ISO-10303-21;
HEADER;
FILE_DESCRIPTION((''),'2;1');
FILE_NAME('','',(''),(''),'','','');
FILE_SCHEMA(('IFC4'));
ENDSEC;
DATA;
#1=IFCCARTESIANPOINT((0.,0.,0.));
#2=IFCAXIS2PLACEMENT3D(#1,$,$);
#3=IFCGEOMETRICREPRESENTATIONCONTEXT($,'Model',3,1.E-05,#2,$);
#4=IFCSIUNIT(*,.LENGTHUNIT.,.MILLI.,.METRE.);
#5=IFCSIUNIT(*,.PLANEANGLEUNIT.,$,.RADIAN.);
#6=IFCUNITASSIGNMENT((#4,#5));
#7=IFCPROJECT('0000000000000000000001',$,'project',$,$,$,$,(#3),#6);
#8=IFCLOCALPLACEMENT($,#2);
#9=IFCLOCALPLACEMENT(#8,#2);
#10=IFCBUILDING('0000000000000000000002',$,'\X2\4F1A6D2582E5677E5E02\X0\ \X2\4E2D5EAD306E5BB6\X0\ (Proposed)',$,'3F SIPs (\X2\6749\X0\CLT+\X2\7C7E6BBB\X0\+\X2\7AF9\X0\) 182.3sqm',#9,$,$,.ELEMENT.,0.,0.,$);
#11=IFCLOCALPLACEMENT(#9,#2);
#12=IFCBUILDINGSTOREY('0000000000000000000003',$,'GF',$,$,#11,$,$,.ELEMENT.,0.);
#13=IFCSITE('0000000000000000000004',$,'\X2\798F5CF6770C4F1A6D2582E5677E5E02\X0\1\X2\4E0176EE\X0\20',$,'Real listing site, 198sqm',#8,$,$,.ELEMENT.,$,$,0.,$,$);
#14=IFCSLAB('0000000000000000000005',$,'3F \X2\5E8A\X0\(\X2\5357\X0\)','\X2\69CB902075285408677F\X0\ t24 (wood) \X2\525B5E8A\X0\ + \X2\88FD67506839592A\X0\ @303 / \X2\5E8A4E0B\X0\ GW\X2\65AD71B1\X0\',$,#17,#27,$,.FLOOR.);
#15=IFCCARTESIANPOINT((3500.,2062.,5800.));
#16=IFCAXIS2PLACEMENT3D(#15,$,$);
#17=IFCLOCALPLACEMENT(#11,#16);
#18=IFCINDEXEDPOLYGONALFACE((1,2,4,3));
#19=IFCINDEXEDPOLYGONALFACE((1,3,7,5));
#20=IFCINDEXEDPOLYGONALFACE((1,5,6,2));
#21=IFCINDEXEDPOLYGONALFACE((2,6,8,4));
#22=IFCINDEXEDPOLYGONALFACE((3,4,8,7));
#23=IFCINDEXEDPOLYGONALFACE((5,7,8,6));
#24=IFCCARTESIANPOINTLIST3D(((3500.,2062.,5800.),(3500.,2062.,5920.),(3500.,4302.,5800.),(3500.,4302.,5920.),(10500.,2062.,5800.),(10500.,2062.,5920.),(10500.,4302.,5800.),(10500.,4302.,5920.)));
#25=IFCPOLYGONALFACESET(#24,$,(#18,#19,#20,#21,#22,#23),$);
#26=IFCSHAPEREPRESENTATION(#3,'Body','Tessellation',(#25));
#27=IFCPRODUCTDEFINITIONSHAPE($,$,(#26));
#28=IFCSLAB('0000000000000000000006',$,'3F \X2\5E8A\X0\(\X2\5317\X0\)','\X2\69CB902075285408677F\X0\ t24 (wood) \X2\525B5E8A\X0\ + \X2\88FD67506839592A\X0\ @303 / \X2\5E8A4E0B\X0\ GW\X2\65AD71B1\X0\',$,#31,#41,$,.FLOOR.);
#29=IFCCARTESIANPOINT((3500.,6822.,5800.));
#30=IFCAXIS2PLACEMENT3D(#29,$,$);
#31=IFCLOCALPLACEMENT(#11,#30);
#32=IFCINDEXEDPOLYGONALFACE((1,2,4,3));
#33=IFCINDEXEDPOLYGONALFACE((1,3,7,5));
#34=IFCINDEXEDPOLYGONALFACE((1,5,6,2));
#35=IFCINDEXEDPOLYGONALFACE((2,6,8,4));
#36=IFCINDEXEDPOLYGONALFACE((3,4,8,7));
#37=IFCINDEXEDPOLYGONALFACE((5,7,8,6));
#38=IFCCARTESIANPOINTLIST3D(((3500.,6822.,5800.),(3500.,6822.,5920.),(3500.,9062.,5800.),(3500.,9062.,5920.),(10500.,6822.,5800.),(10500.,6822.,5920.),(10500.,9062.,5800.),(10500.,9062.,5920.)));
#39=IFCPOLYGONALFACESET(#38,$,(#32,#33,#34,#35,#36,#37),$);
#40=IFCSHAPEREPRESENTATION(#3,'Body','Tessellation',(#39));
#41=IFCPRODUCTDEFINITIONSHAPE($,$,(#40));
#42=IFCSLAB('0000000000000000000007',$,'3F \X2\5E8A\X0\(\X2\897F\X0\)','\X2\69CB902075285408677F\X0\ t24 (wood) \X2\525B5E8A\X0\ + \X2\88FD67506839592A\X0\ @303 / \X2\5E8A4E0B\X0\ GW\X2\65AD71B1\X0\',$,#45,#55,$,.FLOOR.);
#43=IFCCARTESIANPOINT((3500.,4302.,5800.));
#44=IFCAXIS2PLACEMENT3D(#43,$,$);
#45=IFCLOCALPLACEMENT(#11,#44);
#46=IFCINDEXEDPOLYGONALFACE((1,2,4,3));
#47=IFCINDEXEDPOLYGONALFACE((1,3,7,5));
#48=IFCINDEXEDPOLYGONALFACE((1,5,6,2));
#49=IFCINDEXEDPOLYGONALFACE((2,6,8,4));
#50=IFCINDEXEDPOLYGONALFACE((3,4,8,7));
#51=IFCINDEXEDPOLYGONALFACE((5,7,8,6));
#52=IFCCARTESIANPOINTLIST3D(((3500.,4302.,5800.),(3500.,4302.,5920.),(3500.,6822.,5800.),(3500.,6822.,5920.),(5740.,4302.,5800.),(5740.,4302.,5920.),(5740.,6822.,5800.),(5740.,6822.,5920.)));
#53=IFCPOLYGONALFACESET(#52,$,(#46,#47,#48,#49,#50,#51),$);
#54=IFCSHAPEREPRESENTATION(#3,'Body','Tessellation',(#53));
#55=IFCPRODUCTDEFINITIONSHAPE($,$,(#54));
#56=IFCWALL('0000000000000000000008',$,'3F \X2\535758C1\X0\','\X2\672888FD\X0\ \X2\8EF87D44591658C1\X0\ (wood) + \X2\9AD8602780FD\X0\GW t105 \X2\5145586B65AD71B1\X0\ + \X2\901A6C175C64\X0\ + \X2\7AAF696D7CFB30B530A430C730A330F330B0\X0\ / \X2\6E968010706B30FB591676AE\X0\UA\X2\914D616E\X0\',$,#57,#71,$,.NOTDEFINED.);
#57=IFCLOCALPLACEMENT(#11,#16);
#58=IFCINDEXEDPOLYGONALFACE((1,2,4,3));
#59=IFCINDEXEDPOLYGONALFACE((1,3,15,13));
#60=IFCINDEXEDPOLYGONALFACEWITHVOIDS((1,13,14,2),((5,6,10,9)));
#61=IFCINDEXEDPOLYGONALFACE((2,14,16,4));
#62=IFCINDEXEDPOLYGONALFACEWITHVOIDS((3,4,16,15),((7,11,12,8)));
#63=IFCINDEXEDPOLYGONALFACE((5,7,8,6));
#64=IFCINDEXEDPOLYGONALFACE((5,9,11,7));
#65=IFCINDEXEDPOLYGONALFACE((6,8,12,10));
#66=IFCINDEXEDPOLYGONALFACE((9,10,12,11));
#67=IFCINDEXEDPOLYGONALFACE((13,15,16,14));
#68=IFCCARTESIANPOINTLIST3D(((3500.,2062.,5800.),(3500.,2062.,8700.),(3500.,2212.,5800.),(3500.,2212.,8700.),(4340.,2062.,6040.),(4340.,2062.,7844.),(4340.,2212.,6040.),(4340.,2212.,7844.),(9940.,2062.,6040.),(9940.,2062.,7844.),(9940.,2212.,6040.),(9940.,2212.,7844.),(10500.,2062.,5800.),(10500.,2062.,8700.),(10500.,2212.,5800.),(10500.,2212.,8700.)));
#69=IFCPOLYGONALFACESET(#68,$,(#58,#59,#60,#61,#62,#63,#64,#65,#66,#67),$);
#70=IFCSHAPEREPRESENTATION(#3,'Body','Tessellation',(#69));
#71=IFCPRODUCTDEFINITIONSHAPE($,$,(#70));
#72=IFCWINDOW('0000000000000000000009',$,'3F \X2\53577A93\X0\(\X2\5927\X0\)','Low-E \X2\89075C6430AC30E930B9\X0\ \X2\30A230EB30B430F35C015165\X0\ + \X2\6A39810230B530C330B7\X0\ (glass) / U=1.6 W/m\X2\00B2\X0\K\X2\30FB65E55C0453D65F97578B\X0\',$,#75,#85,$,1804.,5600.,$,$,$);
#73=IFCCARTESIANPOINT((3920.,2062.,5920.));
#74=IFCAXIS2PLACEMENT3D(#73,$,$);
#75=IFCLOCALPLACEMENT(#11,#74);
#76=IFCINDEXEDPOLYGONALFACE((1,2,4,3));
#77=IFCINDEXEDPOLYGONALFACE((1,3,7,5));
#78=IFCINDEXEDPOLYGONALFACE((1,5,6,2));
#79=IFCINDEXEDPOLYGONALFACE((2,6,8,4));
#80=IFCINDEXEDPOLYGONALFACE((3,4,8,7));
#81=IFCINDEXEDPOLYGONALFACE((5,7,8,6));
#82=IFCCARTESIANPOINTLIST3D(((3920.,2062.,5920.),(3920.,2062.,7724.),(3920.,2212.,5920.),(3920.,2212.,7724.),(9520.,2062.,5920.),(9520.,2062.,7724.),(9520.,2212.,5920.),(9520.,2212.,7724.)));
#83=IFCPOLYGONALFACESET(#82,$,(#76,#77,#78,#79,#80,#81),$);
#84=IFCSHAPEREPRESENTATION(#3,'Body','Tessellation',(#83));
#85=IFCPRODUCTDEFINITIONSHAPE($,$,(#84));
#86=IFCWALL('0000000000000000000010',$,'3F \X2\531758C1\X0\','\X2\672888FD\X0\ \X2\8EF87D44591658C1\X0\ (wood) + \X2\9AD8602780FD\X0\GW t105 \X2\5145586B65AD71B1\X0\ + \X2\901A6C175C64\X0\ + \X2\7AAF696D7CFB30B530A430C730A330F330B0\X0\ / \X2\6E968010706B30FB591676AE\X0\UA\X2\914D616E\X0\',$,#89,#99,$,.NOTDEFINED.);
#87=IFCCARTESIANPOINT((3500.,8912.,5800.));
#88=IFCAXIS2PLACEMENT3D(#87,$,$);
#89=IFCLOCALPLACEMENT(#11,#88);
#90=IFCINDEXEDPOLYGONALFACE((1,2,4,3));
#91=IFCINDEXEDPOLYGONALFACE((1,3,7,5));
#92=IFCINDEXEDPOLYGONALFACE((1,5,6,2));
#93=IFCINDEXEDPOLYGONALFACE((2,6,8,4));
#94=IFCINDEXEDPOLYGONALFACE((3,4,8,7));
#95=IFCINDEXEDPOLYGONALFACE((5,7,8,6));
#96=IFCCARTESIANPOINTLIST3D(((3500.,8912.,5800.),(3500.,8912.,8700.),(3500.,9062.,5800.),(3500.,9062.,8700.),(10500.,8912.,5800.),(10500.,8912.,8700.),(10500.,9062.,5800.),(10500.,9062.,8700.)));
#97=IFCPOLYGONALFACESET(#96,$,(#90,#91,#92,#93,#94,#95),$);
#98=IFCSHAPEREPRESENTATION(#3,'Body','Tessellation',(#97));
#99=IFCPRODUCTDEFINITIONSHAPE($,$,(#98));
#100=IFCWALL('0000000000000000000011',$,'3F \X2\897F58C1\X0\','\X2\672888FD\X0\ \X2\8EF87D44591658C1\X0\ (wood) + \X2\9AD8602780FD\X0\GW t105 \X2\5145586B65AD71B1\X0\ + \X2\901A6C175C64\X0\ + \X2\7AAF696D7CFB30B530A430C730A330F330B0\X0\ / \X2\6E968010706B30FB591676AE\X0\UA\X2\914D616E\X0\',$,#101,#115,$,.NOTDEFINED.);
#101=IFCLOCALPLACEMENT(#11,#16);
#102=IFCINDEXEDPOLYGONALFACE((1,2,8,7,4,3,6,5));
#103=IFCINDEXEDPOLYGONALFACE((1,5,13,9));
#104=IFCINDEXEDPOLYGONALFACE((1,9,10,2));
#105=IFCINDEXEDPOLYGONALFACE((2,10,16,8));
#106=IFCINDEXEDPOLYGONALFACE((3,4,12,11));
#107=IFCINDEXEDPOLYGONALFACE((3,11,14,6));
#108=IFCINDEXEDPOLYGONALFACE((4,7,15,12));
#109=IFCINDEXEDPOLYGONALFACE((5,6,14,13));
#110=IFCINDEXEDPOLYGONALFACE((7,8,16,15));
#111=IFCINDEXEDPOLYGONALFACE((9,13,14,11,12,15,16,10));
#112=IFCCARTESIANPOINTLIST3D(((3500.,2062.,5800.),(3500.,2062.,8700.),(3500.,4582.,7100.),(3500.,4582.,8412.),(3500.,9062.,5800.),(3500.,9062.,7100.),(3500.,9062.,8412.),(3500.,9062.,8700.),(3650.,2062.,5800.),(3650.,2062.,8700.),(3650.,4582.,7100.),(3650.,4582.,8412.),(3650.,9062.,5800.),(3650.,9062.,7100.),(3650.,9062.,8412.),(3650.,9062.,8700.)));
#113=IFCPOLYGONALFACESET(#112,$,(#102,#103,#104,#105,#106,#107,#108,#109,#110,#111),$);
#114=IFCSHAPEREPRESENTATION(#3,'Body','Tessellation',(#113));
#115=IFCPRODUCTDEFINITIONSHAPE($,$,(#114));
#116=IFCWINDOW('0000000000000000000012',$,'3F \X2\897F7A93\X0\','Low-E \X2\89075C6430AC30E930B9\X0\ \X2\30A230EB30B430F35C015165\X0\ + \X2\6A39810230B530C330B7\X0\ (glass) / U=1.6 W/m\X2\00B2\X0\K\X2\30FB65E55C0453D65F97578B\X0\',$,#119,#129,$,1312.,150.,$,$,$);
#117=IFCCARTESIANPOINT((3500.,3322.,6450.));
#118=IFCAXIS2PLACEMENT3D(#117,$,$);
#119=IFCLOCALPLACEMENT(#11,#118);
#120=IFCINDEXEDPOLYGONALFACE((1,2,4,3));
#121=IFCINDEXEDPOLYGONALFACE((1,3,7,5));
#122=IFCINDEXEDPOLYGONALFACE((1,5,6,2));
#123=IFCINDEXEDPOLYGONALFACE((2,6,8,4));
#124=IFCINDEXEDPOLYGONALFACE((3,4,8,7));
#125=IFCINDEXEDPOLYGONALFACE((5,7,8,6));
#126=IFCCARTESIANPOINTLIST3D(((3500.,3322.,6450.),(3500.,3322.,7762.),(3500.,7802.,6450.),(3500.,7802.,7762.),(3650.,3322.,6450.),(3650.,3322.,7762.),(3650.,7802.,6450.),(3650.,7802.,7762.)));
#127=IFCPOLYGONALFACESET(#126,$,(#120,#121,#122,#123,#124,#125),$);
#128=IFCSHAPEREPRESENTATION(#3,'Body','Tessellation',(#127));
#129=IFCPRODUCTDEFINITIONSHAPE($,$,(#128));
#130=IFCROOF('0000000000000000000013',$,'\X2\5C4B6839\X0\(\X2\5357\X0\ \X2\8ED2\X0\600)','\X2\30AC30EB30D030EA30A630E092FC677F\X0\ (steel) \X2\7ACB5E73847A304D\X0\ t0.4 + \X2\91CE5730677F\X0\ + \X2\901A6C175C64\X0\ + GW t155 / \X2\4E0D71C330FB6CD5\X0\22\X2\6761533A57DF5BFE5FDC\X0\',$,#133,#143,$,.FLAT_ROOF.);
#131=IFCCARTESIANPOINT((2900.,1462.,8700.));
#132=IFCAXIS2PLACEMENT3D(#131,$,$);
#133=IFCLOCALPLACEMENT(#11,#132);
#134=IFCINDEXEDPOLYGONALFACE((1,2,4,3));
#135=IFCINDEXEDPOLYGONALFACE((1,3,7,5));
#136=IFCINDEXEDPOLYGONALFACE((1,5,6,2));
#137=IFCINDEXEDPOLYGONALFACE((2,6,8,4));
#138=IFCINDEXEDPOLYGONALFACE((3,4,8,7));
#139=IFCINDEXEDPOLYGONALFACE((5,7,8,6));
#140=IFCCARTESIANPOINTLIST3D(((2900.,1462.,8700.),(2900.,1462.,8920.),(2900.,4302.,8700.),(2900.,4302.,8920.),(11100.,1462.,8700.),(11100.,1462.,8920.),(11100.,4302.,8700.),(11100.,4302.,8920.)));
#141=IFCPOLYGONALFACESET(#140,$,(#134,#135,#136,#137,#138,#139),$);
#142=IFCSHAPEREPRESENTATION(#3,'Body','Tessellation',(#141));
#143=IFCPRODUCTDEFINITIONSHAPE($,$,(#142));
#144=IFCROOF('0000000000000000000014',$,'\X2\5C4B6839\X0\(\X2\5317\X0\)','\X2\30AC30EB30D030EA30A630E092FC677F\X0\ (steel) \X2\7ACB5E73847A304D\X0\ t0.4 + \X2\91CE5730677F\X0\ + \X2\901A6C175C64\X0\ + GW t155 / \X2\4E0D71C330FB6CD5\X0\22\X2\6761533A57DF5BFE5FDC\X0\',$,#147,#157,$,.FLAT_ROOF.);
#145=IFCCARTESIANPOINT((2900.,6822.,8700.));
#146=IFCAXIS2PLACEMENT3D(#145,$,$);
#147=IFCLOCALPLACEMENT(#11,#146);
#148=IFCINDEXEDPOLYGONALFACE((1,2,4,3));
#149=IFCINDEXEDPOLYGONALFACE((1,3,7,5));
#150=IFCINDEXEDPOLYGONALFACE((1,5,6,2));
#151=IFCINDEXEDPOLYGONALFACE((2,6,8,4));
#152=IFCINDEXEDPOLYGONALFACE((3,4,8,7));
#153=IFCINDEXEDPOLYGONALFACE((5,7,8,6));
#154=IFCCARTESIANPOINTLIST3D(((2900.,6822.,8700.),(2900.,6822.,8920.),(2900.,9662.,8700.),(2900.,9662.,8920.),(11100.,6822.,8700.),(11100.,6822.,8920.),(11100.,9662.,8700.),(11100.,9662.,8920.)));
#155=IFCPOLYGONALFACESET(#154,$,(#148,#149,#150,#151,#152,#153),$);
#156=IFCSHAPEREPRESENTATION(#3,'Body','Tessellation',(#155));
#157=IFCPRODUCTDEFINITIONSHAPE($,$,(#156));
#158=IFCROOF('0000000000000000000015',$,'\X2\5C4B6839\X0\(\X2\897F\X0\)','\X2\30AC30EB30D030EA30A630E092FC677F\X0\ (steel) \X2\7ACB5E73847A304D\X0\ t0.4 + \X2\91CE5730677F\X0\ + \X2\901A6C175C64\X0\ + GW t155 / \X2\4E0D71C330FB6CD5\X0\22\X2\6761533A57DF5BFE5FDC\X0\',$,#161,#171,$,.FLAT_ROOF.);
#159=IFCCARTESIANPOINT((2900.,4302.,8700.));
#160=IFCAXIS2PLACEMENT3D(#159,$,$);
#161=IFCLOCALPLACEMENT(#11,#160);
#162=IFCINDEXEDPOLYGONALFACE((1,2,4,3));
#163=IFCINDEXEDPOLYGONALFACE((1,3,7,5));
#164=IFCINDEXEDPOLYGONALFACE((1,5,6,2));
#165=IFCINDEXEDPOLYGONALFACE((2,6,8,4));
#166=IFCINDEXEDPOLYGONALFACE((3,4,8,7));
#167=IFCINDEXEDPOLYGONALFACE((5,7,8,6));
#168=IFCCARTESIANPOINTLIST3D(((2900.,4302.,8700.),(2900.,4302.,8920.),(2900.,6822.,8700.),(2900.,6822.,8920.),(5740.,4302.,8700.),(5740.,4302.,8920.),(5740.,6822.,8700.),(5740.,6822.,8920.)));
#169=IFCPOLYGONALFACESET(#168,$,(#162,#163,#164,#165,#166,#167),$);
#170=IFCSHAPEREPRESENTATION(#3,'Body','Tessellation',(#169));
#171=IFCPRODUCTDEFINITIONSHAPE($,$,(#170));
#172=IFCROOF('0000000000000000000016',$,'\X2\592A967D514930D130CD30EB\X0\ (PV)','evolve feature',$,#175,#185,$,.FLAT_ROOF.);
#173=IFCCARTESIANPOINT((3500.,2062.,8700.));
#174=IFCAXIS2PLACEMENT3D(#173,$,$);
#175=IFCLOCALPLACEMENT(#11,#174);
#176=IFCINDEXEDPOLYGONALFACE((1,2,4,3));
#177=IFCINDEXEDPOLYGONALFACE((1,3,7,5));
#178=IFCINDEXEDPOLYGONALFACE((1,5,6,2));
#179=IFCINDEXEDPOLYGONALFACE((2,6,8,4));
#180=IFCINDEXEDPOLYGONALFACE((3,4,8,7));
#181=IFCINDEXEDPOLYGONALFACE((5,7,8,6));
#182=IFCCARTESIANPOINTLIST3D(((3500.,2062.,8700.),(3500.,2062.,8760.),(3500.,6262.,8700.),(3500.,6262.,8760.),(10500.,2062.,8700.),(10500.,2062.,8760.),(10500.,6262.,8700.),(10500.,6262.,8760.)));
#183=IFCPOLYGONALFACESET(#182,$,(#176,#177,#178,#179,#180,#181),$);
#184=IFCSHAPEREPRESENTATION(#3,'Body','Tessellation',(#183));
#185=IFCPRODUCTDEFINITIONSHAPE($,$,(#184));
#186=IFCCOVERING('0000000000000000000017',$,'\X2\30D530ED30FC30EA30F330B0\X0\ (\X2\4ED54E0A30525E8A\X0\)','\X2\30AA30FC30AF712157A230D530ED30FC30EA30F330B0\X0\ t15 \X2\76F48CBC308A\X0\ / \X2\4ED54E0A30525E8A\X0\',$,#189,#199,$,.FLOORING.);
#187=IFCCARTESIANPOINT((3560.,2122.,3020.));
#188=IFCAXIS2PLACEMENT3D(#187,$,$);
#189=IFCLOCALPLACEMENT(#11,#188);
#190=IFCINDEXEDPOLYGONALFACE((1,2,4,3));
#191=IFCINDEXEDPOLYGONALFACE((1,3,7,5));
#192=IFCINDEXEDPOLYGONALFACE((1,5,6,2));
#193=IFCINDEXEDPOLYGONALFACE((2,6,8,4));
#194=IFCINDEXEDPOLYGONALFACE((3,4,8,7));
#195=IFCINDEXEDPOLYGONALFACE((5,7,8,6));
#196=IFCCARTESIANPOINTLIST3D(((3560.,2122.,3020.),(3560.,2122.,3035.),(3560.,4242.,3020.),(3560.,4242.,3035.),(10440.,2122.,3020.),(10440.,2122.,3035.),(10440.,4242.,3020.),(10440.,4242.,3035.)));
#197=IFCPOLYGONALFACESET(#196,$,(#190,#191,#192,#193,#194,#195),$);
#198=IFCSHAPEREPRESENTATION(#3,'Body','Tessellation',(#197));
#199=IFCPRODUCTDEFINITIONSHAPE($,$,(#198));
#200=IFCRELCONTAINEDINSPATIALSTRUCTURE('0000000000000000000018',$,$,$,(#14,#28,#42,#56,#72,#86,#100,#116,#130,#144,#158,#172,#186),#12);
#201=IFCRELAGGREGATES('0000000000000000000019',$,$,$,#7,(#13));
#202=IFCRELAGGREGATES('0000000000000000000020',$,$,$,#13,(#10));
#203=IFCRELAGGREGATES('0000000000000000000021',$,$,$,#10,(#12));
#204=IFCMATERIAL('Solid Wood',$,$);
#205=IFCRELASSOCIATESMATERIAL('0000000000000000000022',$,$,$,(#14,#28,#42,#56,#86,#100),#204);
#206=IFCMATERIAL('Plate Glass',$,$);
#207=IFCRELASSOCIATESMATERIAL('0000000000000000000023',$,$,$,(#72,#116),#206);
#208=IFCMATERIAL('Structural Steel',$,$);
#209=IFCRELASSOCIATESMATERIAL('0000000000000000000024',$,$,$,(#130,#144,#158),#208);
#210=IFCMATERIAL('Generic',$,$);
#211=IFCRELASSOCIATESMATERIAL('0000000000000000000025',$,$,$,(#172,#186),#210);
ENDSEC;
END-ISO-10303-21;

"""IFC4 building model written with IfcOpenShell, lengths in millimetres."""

from ifc_helpers import new_model, si_unit, frame, frame_2d, origin, place, context, project, spatial, rectangle, extrude, material, element, fill, save


model = new_model("IFC4")

# Units and contexts
model_context = context("Model", 3, precision=1e-05, world=origin())
ifc_project = project(units=[si_unit("LENGTHUNIT", "METRE", prefix="MILLI"), si_unit("PLANEANGLEUNIT", "RADIAN")], contexts=[model_context])

# Site, building, storey
site_placement = place(None, origin())
site = spatial("IfcSite", under=ifc_project, at=site_placement, Name="福島県会津若松市1丁目20", ObjectType="Real listing site, 198sqm", CompositionType="ELEMENT", RefElevation=0.0)
building_placement = place(site_placement, origin())
building = spatial("IfcBuilding", under=site, at=building_placement, Name="会津若松市 中庭の家 (Proposed)", ObjectType="3F SIPs (杉CLT+籾殻+竹) 182.3sqm", CompositionType="ELEMENT", ElevationOfRefHeight=0.0, ElevationOfTerrain=0.0)
storey_placement = place(building_placement, origin())
storey = spatial("IfcBuildingStorey", under=building, at=storey_placement, Name="GF", CompositionType="ELEMENT", Elevation=0.0)

# Slabs
ifc_material_1 = material(Name="Solid Wood")
slab_1_placement = place(storey_placement, frame((3500.0, 2062.0, 5800.0)))
element("IfcSlab", 1, at=slab_1_placement, inside=storey, material=ifc_material_1, Name="3F 床(南)", Description="構造用合板 t24 (wood) 剛床 + 製材根太 @303 / 床下 GW断熱", PredefinedType="FLOOR", context=model_context, shape_type="SweptSolid", body=[
    extrude(rectangle(XDim=7000.0, YDim=2240.0, at=frame_2d((3500.0, 1120.0))), frame((3500.0, 2062.0, 5800.0)), (0.0, 0.0, 1.0), 120.0),
])
slab_2_placement = place(storey_placement, frame((3500.0, 6822.0, 5800.0)))
element("IfcSlab", 2, at=slab_2_placement, inside=storey, material=ifc_material_1, Name="3F 床(北)", Description="構造用合板 t24 (wood) 剛床 + 製材根太 @303 / 床下 GW断熱", PredefinedType="FLOOR", context=model_context, shape_type="SweptSolid", body=[
    extrude(rectangle(XDim=7000.0, YDim=2240.0, at=frame_2d((3500.0, 1120.0))), frame((3500.0, 6822.0, 5800.0)), (0.0, 0.0, 1.0), 120.0),
])
slab_3_placement = place(storey_placement, frame((3500.0, 4302.0, 5800.0)))
element("IfcSlab", 3, at=slab_3_placement, inside=storey, material=ifc_material_1, Name="3F 床(西)", Description="構造用合板 t24 (wood) 剛床 + 製材根太 @303 / 床下 GW断熱", PredefinedType="FLOOR", context=model_context, shape_type="SweptSolid", body=[
    extrude(rectangle(XDim=2240.0, YDim=2520.0, at=frame_2d((1120.0, 1260.0))), frame((3500.0, 4302.0, 5800.0)), (0.0, 0.0, 1.0), 120.0),
])

# Wall, opening, window
wall_1_placement = place(storey_placement, frame((3500.0, 2062.0, 5800.0)))
wall_1 = element("IfcWall", 4, at=wall_1_placement, inside=storey, material=ifc_material_1, Name="3F 南壁", Description="木製 軸組外壁 (wood) + 高性能GW t105 充填断熱 + 通気層 + 窯業系サイディング / 準耐火・外皮UA配慮", PredefinedType="NOTDEFINED", context=model_context, shape_type="SweptSolid", body=[
    extrude(rectangle(XDim=7000.0, YDim=150.0, at=frame_2d((3500.0, 75.0))), frame((3500.0, 2062.0, 5800.0)), (0.0, 0.0, 1.0), 2900.0),
])
opening_1_placement = place(storey_placement, frame((3920.0, 2062.0, 5920.0)))
opening_1 = element("IfcOpeningElement", 5, at=opening_1_placement, cuts=wall_1, PredefinedType="NOTDEFINED", context=model_context, shape_type="SweptSolid", body=[
    extrude(rectangle(XDim=5600.0, YDim=150.0, at=frame_2d((2800.0, 75.0))), frame((3920.0, 2062.0, 5920.0)), (0.0, 0.0, 1.0), 1804.0),
])
ifc_material_2 = material(Name="Plate Glass")
window_1_placement = place(storey_placement, frame((3920.0, 2062.0, 5920.0)))
window_1 = element("IfcWindow", 6, at=window_1_placement, inside=storey, material=ifc_material_2, Name="3F 南窓(大)", Description="Low-E 複層ガラス アルゴン封入 + 樹脂サッシ (glass) / U=1.6 W/m²K・日射取得型", OverallHeight=1804.0, OverallWidth=5600.0, context=model_context, shape_type="SweptSolid", body=[
    extrude(rectangle(XDim=5600.0, YDim=150.0, at=frame_2d((2800.0, 75.0))), frame((3920.0, 2062.0, 5920.0)), (0.0, 0.0, 1.0), 1804.0),
])
fill(opening_1, window_1)

# Wall
wall_2_placement = place(storey_placement, frame((3500.0, 8912.0, 5800.0)))
element("IfcWall", 7, at=wall_2_placement, inside=storey, material=ifc_material_1, Name="3F 北壁", Description="木製 軸組外壁 (wood) + 高性能GW t105 充填断熱 + 通気層 + 窯業系サイディング / 準耐火・外皮UA配慮", PredefinedType="NOTDEFINED", context=model_context, shape_type="SweptSolid", body=[
    extrude(rectangle(XDim=7000.0, YDim=150.0, at=frame_2d((3500.0, 75.0))), frame((3500.0, 8912.0, 5800.0)), (0.0, 0.0, 1.0), 2900.0),
])

# Wall, opening, window
wall_3_placement = place(storey_placement, frame((3500.0, 2062.0, 5800.0)))
wall_3 = element("IfcWall", 8, at=wall_3_placement, inside=storey, material=ifc_material_1, Name="3F 西壁", Description="木製 軸組外壁 (wood) + 高性能GW t105 充填断熱 + 通気層 + 窯業系サイディング / 準耐火・外皮UA配慮", PredefinedType="NOTDEFINED", context=model_context, shape_type="SweptSolid", body=[
    extrude(rectangle(XDim=150.0, YDim=7000.0, at=frame_2d((75.0, 3500.0))), frame((3500.0, 2062.0, 5800.0)), (0.0, 0.0, 1.0), 2900.0),
])
opening_2_placement = place(storey_placement, frame((3500.0, 3322.0, 6450.0)))
opening_2 = element("IfcOpeningElement", 9, at=opening_2_placement, cuts=wall_3, PredefinedType="NOTDEFINED", context=model_context, shape_type="SweptSolid", body=[
    extrude(rectangle(XDim=150.0, YDim=4480.0, at=frame_2d((75.0, 2240.0))), frame((3500.0, 3322.0, 6450.0)), (0.0, 0.0, 1.0), 1312.0),
])
window_2_placement = place(storey_placement, frame((3500.0, 3322.0, 6450.0)))
window_2 = element("IfcWindow", 10, at=window_2_placement, inside=storey, material=ifc_material_2, Name="3F 西窓", Description="Low-E 複層ガラス アルゴン封入 + 樹脂サッシ (glass) / U=1.6 W/m²K・日射取得型", OverallHeight=1312.0, OverallWidth=150.0, context=model_context, shape_type="SweptSolid", body=[
    extrude(rectangle(XDim=150.0, YDim=4480.0, at=frame_2d((75.0, 2240.0))), frame((3500.0, 3322.0, 6450.0)), (0.0, 0.0, 1.0), 1312.0),
])
fill(opening_2, window_2)

# Roofs
ifc_material_3 = material(Name="Structural Steel")
roof_1_placement = place(storey_placement, frame((2900.0, 1462.0, 8700.0)))
element("IfcRoof", 11, at=roof_1_placement, inside=storey, material=ifc_material_3, Name="屋根(南 軒600)", Description="ガルバリウム鋼板 (steel) 立平葺き t0.4 + 野地板 + 通気層 + GW t155 / 不燃・法22条区域対応", PredefinedType="FLAT_ROOF", context=model_context, shape_type="SweptSolid", body=[
    extrude(rectangle(XDim=8200.0, YDim=2840.0, at=frame_2d((4100.0, 1420.0))), frame((2900.0, 1462.0, 8700.0)), (0.0, 0.0, 1.0), 220.0),
])
roof_2_placement = place(storey_placement, frame((2900.0, 6822.0, 8700.0)))
element("IfcRoof", 12, at=roof_2_placement, inside=storey, material=ifc_material_3, Name="屋根(北)", Description="ガルバリウム鋼板 (steel) 立平葺き t0.4 + 野地板 + 通気層 + GW t155 / 不燃・法22条区域対応", PredefinedType="FLAT_ROOF", context=model_context, shape_type="SweptSolid", body=[
    extrude(rectangle(XDim=8200.0, YDim=2840.0, at=frame_2d((4100.0, 1420.0))), frame((2900.0, 6822.0, 8700.0)), (0.0, 0.0, 1.0), 220.0),
])
roof_3_placement = place(storey_placement, frame((2900.0, 4302.0, 8700.0)))
element("IfcRoof", 13, at=roof_3_placement, inside=storey, material=ifc_material_3, Name="屋根(西)", Description="ガルバリウム鋼板 (steel) 立平葺き t0.4 + 野地板 + 通気層 + GW t155 / 不燃・法22条区域対応", PredefinedType="FLAT_ROOF", context=model_context, shape_type="SweptSolid", body=[
    extrude(rectangle(XDim=2840.0, YDim=2520.0, at=frame_2d((1420.0, 1260.0))), frame((2900.0, 4302.0, 8700.0)), (0.0, 0.0, 1.0), 220.0),
])
ifc_material_4 = material(Name="Generic")
roof_4_placement = place(storey_placement, frame((3500.0, 2062.0, 8700.0)))
element("IfcRoof", 14, at=roof_4_placement, inside=storey, material=ifc_material_4, Name="太陽光パネル (PV)", Description="evolve feature", PredefinedType="FLAT_ROOF", context=model_context, shape_type="SweptSolid", body=[
    extrude(rectangle(XDim=7000.0, YDim=4200.0, at=frame_2d((3500.0, 2100.0))), frame((3500.0, 2062.0, 8700.0)), (0.0, 0.0, 1.0), 60.0),
])

# Covering
covering_1_placement = place(storey_placement, frame((3560.0, 2122.0, 3020.0)))
element("IfcCovering", 15, at=covering_1_placement, inside=storey, material=ifc_material_4, Name="フローリング (仕上げ床)", Description="オーク無垢フローリング t15 直貼り / 仕上げ床", PredefinedType="FLOORING", context=model_context, shape_type="SweptSolid", body=[
    extrude(rectangle(XDim=6880.0, YDim=2120.0, at=frame_2d((3440.0, 1060.0))), frame((3560.0, 2122.0, 3020.0)), (0.0, 0.0, 1.0), 15.0),
])

save(model, "model.ifc")
